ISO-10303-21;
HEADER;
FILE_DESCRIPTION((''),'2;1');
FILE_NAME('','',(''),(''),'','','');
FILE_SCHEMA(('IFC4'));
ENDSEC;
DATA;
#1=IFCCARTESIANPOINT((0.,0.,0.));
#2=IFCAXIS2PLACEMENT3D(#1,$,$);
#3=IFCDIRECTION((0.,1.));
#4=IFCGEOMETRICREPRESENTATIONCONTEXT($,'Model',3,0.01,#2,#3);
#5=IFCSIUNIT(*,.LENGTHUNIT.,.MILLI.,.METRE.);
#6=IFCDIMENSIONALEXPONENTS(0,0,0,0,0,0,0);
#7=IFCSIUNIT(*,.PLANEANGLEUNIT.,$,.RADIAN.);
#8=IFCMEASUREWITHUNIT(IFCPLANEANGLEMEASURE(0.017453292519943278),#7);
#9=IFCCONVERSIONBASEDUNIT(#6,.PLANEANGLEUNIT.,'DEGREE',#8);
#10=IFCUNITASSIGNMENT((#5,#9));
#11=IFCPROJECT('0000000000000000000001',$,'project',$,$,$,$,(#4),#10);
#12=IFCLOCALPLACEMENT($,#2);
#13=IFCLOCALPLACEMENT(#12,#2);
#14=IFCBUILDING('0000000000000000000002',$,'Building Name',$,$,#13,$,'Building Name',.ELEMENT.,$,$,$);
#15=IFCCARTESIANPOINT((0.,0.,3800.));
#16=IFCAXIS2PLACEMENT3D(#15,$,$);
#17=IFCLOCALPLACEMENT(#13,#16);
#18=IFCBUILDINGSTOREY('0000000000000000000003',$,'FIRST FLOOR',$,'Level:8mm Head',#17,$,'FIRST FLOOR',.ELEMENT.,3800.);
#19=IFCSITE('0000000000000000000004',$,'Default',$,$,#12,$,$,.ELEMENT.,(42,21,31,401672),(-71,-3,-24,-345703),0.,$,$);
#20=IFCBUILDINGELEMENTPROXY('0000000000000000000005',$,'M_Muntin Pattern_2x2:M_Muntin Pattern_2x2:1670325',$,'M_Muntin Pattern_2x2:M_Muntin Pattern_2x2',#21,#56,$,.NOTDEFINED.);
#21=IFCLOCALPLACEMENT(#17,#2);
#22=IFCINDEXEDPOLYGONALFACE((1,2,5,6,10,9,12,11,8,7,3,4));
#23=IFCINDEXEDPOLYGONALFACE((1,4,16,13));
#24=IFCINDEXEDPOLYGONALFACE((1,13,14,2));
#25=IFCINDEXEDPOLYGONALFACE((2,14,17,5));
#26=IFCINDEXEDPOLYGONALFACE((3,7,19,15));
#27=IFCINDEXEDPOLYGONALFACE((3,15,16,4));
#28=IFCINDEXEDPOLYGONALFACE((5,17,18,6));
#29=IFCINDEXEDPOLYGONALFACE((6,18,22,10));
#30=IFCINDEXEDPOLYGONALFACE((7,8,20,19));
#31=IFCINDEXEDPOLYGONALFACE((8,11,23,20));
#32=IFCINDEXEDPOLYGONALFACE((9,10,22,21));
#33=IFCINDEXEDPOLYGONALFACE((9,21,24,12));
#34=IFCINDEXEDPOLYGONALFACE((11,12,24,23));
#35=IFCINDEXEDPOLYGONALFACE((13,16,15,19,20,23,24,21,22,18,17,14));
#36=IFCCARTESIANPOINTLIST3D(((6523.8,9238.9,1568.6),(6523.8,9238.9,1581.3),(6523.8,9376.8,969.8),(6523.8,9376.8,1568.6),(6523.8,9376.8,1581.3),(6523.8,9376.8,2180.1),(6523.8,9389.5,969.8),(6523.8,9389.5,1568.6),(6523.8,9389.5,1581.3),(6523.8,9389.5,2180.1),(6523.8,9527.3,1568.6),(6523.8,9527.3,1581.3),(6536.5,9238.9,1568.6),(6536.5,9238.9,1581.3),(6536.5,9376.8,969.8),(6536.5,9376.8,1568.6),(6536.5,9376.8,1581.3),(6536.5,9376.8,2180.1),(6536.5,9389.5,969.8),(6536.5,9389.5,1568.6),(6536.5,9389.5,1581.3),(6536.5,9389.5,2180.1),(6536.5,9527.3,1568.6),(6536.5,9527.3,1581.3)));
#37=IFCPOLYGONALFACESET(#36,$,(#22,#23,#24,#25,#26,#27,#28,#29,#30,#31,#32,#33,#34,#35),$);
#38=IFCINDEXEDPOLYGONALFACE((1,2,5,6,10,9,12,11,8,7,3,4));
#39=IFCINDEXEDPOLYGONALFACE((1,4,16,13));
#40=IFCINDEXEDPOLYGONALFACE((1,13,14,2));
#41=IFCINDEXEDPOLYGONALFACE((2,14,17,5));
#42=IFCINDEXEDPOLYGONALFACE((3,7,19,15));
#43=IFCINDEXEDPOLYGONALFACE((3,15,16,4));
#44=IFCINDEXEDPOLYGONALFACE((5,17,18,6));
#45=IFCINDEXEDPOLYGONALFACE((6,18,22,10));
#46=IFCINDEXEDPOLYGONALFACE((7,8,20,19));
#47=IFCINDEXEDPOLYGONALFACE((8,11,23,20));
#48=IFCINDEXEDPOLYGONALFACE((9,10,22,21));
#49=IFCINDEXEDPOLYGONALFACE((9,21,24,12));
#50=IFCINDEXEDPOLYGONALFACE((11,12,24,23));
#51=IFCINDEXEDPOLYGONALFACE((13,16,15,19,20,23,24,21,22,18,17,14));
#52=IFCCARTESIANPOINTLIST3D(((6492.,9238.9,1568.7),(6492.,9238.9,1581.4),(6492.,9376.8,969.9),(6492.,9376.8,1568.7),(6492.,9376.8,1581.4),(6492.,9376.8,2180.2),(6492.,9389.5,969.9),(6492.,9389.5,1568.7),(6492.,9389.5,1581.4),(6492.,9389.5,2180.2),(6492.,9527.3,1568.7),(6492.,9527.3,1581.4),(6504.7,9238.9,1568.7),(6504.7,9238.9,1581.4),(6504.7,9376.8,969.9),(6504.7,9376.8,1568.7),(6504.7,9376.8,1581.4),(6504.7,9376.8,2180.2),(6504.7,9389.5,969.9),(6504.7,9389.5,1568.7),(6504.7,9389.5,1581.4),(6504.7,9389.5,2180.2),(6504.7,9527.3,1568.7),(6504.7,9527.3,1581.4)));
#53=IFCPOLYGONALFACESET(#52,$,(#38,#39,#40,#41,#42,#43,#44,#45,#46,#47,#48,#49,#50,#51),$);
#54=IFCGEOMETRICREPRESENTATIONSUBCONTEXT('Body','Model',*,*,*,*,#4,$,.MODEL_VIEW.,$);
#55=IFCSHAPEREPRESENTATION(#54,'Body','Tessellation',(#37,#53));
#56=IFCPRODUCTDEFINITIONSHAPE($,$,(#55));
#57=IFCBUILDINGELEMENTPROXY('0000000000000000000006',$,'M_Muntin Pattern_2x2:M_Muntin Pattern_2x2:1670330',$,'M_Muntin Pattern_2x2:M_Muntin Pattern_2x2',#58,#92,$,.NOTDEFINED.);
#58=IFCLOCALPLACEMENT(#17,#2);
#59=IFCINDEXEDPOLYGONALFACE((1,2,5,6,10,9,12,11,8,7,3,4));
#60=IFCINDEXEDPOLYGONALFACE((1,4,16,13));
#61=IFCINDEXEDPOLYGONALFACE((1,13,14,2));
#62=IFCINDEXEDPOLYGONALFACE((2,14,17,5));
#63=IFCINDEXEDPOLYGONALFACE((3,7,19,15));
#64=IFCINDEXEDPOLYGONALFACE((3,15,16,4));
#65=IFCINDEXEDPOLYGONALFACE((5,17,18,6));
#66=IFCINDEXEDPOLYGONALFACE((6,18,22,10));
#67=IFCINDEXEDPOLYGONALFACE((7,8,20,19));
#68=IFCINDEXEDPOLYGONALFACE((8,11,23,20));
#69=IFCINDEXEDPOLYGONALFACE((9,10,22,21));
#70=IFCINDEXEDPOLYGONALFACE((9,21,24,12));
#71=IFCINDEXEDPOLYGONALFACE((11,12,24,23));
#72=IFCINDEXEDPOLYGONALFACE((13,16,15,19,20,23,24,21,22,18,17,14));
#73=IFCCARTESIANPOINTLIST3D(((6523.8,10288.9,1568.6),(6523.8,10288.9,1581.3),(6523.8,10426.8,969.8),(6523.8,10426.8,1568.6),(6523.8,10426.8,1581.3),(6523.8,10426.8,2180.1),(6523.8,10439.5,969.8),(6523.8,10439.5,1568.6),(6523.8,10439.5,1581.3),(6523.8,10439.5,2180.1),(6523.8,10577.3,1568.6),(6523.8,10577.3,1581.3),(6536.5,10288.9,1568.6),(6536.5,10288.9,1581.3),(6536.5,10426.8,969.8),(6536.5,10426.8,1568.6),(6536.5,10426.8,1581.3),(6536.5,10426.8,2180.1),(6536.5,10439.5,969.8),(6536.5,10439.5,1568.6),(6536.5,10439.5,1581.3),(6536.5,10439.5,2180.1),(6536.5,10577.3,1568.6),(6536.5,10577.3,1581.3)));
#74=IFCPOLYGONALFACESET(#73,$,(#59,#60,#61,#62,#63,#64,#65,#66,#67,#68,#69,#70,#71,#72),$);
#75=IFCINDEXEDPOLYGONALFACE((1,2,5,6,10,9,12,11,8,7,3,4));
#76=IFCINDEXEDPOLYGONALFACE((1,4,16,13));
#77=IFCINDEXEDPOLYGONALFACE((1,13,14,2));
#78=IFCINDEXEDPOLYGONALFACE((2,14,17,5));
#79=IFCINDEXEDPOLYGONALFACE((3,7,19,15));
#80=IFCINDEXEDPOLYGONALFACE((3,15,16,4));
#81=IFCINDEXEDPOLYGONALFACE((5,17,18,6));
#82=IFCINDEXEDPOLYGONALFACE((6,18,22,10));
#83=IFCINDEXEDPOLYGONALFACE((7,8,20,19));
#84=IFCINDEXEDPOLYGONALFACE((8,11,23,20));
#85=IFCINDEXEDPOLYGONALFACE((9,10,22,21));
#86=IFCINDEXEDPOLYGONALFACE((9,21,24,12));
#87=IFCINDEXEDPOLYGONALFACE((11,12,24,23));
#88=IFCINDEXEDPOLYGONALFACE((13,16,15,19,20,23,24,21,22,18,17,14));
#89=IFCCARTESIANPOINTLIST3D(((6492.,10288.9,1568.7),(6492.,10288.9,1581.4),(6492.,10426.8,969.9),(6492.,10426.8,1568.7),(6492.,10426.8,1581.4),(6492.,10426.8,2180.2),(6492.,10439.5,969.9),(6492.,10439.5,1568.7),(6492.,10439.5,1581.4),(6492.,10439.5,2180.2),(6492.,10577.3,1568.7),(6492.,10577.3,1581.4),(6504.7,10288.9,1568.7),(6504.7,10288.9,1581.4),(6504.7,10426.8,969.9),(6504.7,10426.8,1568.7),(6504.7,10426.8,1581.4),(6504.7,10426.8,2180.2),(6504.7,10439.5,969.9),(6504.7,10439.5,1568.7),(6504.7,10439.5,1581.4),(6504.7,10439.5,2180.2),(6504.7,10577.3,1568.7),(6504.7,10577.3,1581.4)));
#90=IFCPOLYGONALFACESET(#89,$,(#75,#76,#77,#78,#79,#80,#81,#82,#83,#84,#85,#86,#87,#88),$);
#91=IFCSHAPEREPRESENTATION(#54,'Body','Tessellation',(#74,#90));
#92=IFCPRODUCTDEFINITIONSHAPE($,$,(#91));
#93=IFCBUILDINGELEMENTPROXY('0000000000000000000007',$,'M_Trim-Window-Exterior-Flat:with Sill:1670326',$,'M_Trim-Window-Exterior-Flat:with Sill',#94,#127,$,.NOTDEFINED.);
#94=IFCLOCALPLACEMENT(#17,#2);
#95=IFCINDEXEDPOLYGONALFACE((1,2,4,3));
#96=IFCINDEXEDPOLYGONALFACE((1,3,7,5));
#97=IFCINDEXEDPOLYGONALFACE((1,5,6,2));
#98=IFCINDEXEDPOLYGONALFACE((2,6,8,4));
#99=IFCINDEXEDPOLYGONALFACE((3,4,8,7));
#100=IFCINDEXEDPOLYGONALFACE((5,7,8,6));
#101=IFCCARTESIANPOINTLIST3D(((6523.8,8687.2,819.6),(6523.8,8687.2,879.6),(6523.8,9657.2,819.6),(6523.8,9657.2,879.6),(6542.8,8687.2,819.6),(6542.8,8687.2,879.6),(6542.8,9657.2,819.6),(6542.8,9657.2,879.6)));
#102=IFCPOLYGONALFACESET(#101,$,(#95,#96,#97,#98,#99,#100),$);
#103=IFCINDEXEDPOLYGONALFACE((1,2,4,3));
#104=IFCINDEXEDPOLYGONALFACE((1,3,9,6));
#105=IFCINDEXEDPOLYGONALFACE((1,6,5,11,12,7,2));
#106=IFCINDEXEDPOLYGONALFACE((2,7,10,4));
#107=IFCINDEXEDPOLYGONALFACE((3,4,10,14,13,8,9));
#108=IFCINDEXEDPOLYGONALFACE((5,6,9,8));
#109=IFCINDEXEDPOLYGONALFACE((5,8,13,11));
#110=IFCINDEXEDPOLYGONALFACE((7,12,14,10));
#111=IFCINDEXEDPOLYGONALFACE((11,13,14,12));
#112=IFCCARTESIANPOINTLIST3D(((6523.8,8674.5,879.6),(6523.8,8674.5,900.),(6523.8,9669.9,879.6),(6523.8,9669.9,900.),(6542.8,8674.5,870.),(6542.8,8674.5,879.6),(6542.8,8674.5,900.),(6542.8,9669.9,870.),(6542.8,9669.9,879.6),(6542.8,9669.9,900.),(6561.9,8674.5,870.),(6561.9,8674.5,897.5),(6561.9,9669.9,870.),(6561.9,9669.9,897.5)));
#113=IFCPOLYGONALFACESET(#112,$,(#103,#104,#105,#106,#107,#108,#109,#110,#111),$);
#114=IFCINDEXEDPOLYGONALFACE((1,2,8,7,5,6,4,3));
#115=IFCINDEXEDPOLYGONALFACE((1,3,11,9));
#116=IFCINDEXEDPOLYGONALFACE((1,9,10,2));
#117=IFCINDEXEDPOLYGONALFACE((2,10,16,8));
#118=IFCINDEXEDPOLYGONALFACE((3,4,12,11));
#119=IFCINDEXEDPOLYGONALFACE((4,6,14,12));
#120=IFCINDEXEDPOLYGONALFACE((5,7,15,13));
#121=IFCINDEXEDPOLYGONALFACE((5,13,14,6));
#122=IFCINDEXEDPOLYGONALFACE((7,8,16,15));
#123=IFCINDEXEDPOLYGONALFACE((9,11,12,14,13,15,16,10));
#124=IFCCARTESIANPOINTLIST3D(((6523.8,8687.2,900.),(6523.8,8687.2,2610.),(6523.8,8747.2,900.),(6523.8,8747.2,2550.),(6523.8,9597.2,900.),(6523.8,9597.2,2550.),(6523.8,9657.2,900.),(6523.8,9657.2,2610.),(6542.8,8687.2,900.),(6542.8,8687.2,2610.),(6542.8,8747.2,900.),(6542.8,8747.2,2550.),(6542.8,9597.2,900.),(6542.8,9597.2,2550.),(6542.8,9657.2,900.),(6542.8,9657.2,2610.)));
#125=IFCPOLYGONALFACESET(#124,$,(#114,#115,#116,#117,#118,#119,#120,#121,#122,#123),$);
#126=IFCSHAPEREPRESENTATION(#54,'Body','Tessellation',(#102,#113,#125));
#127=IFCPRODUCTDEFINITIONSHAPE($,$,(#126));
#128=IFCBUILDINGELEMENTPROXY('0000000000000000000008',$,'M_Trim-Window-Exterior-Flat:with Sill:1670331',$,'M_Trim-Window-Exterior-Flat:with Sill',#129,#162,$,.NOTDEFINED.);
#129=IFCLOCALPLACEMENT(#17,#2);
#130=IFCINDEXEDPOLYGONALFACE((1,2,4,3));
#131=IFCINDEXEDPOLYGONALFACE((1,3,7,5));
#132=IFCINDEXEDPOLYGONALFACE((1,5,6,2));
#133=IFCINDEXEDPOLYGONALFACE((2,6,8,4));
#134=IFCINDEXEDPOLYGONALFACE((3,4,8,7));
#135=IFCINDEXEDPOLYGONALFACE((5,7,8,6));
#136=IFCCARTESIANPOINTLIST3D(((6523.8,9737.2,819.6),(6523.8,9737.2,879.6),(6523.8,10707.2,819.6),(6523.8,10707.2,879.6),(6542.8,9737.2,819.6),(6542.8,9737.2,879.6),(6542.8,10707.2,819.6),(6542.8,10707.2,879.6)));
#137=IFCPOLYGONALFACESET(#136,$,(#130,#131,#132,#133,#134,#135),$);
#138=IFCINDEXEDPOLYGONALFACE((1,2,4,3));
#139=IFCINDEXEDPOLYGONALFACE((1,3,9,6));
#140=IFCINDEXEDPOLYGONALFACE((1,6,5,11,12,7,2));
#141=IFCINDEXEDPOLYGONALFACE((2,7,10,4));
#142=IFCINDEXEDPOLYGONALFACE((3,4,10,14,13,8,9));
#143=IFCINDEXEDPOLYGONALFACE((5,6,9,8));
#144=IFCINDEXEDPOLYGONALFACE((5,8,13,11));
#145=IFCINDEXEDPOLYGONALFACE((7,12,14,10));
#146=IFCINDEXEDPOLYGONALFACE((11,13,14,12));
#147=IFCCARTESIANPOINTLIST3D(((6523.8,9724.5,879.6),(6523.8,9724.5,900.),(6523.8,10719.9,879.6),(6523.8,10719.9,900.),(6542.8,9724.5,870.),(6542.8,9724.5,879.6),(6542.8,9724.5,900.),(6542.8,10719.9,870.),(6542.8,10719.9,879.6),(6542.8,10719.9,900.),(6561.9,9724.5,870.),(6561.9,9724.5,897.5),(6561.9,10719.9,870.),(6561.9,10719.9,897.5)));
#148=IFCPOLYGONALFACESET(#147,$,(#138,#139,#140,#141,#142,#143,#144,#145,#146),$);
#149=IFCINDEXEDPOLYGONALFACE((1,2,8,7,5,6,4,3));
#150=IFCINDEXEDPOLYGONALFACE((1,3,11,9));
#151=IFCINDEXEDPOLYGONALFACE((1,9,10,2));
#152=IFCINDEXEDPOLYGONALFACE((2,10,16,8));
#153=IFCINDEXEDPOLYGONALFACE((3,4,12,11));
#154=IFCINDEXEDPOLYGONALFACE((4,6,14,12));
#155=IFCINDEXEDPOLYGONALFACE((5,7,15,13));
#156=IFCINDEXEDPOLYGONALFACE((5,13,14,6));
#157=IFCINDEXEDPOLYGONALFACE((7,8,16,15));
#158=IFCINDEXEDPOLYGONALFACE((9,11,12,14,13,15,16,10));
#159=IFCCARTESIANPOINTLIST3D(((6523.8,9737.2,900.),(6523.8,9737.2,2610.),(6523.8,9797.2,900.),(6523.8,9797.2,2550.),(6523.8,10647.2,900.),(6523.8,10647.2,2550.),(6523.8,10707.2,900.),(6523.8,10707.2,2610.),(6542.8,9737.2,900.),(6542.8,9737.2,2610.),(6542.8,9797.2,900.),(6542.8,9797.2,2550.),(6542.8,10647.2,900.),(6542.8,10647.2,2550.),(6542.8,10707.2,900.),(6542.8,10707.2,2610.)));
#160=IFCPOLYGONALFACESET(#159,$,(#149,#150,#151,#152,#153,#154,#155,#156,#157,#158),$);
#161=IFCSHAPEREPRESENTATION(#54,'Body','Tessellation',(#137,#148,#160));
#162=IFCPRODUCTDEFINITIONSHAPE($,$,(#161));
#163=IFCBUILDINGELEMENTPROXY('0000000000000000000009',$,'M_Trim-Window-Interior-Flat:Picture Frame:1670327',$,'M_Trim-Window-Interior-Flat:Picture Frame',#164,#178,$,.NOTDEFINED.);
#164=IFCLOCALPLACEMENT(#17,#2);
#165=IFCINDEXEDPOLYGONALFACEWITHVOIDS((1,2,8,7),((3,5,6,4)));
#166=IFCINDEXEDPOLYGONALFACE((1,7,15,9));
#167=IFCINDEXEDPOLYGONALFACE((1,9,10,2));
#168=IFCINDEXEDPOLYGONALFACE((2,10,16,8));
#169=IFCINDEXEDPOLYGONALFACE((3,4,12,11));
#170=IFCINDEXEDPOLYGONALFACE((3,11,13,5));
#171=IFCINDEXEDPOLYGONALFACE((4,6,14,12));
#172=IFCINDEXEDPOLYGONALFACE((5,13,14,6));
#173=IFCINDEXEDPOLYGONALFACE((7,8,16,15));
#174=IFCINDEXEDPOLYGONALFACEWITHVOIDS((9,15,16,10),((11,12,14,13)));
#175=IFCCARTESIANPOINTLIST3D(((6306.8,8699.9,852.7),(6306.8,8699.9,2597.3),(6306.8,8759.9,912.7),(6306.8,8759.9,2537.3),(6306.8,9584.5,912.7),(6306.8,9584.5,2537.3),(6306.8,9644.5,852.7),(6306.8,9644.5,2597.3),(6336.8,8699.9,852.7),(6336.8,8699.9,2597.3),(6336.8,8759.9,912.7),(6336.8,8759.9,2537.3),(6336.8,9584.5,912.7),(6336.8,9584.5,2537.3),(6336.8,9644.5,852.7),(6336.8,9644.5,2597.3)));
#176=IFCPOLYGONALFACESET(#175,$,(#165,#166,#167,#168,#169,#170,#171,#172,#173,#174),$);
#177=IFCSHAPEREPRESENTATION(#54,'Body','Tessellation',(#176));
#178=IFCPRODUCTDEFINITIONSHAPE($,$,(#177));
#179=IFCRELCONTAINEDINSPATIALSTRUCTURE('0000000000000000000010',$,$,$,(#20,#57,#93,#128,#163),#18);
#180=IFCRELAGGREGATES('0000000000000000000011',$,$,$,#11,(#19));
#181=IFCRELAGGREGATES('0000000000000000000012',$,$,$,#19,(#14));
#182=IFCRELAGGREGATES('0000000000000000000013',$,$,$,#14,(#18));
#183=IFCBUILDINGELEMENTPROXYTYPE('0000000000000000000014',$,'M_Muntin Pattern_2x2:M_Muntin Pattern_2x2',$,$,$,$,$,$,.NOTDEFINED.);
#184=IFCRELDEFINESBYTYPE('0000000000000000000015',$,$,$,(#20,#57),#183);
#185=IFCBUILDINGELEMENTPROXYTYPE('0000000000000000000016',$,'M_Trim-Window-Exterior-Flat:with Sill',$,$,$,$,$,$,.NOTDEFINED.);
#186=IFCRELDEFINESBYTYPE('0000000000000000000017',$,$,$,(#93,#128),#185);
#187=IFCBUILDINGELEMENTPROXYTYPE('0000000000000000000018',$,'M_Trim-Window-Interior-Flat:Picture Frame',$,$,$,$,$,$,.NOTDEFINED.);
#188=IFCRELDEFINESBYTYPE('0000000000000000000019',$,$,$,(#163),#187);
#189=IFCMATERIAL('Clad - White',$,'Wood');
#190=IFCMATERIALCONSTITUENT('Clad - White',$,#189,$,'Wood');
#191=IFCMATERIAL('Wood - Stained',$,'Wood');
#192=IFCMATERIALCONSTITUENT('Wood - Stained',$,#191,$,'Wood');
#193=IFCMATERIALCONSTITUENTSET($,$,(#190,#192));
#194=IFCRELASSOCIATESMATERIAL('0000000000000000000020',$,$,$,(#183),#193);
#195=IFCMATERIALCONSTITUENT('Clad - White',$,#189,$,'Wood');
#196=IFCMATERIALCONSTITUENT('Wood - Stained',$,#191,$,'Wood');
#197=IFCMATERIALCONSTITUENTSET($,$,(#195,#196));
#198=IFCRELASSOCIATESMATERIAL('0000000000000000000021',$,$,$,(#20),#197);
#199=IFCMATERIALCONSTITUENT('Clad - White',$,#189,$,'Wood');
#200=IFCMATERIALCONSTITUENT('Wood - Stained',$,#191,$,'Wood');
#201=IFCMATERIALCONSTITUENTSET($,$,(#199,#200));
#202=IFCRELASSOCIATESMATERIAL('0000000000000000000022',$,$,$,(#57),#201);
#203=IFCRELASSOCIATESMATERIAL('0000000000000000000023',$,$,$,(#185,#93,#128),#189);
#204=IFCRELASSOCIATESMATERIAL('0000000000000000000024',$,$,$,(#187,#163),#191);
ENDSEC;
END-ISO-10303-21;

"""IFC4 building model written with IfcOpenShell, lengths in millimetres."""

from ifc_helpers import new_model, entity, si_unit, converted_unit, direction, frame, origin, place, context, subcontext, project, spatial, indexed_curve, outline, extrude, source, transform, mapped, material, constituent, constituent_set, type_object, type_shapes, element, save


model = new_model("IFC4")

# Units and contexts
model_context = context("Model", 3, precision=0.01, world=origin(), true_north=direction((0.0, 1.0)))
body_context = subcontext(model_context, "Body", "Model", "MODEL_VIEW")
ifc_project = project(units=[si_unit("LENGTHUNIT", "METRE", prefix="MILLI"), converted_unit("PLANEANGLEUNIT", "DEGREE", entity("IfcPlaneAngleMeasure", 0.017453292519943278), si_unit("PLANEANGLEUNIT", "RADIAN"), dimensions=[0, 0, 0, 0, 0, 0, 0])], contexts=[model_context])

# Site, building, storey
site_placement = place(None, origin())
site = spatial("IfcSite", under=ifc_project, at=site_placement, Name="Default", CompositionType="ELEMENT", RefLatitude=(42, 21, 31, 401672), RefLongitude=(-71, -3, -24, -345703), RefElevation=0.0)
building_placement = place(site_placement, origin())
building = spatial("IfcBuilding", under=site, at=building_placement, Name="Building Name", LongName="Building Name", CompositionType="ELEMENT")
storey_placement = place(building_placement, frame((0.0, 0.0, 3800.0)))
storey = spatial("IfcBuildingStorey", under=building, at=storey_placement, Name="FIRST FLOOR", ObjectType="Level:8mm Head", LongName="FIRST FLOOR", CompositionType="ELEMENT", Elevation=3800.0)

# Building element proxies
ifc_material_1 = material(Name="Clad - White", Category="Wood")
ifc_material_2 = material(Name="Wood - Stained", Category="Wood")
ifc_constituent_1 = constituent(ifc_material_1, Name="Clad - White", Category="Wood")
ifc_constituent_2 = constituent(ifc_material_2, Name="Wood - Stained", Category="Wood")
ifc_constituent_set_1 = constituent_set(constituents=[ifc_constituent_1, ifc_constituent_2])
ifc_constituent_3 = constituent(ifc_material_1, Name="Clad - White", Category="Wood")
ifc_constituent_4 = constituent(ifc_material_2, Name="Wood - Stained", Category="Wood")
ifc_constituent_set_2 = constituent_set(constituents=[ifc_constituent_3, ifc_constituent_4])
building_element_proxy_type_1 = type_object("IfcBuildingElementProxyType", Name="M_Muntin Pattern_2x2:M_Muntin Pattern_2x2", PredefinedType="NOTDEFINED", material=ifc_constituent_set_2)
shared_shape_1 = source(origin(), body_context, "Body", "SweptSolid", [
    extrude(outline(indexed_curve([(6.4, -6.4), (605.1, -6.4), (605.1, 6.3), (6.4, 6.3), (6.4, 144.2), (-6.3, 144.2), (-6.3, 6.3), (-605.2, 6.3), (-605.2, -6.4), (-6.3, -6.4), (-6.3, -144.2), (6.4, -144.2), (6.4, -6.4)], self_intersect=False)), frame((0.0, 9.5, 605.1), z_axis=(0.0, 1.0, 0.0), x_axis=(0.0, 0.0, 1.0)), (0.0, 0.0, 1.0), 12.7),
    extrude(outline(indexed_curve([(6.4, -6.4), (605.2, -6.4), (605.2, 6.3), (6.4, 6.3), (6.4, 144.2), (-6.3, 144.2), (-6.3, 6.3), (-605.2, 6.3), (-605.2, -6.4), (-6.3, -6.4), (-6.3, -144.2), (6.4, -144.2), (6.4, -6.4)], self_intersect=False)), frame((0.0, -22.2, 605.2), z_axis=(0.0, 1.0, 0.0), x_axis=(0.0, 0.0, 1.0)), (0.0, 0.0, 1.0), 12.7),
])
type_shapes(building_element_proxy_type_1, [shared_shape_1])
proxy_1_placement = place(storey_placement, frame((6514.3, 9383.1, 969.9), z_axis=(0.0, 0.0, 1.0), x_axis=(0.0, -1.0, 0.0)))
element("IfcBuildingElementProxy", 1, at=proxy_1_placement, inside=storey, type_object=building_element_proxy_type_1, material=ifc_constituent_set_1, Name="M_Muntin Pattern_2x2:M_Muntin Pattern_2x2:1670325", ObjectType="M_Muntin Pattern_2x2:M_Muntin Pattern_2x2", PredefinedType="NOTDEFINED", context=body_context, shape_type="MappedRepresentation", body=[
    mapped(shared_shape_1, transform((0.0, 0.0, 0.0), scale=1.0)),
])
ifc_constituent_5 = constituent(ifc_material_1, Name="Clad - White", Category="Wood")
ifc_constituent_6 = constituent(ifc_material_2, Name="Wood - Stained", Category="Wood")
ifc_constituent_set_3 = constituent_set(constituents=[ifc_constituent_5, ifc_constituent_6])
proxy_2_placement = place(storey_placement, frame((6514.3, 10433.1, 969.9), z_axis=(0.0, 0.0, 1.0), x_axis=(0.0, -1.0, 0.0)))
element("IfcBuildingElementProxy", 2, at=proxy_2_placement, inside=storey, type_object=building_element_proxy_type_1, material=ifc_constituent_set_3, Name="M_Muntin Pattern_2x2:M_Muntin Pattern_2x2:1670330", ObjectType="M_Muntin Pattern_2x2:M_Muntin Pattern_2x2", PredefinedType="NOTDEFINED", context=body_context, shape_type="MappedRepresentation", body=[
    mapped(shared_shape_1, transform((0.0, 0.0, 0.0), scale=1.0)),
])
building_element_proxy_type_2 = type_object("IfcBuildingElementProxyType", Name="M_Trim-Window-Exterior-Flat:with Sill", PredefinedType="NOTDEFINED", material=ifc_material_1)
shared_shape_2 = source(origin(), body_context, "Body", "SweptSolid", [
    extrude(outline(indexed_curve([(-30.0, -485.0), (30.0, -485.0), (30.0, 485.0), (-30.0, 485.0), (-30.0, -485.0)], self_intersect=False)), frame((0.0, 1700.4, 0.0), z_axis=(0.0, 0.0, 1.0), x_axis=(0.0, 1.0, 0.0)), (0.0, 0.0, 1.0), 19.0),
    extrude(outline(indexed_curve([(-15.2, -19.0), (12.3, -19.0), (14.8, 0.0), (14.8, 19.0), (-5.7, 19.0), (-5.7, 0.0), (-15.2, 0.0), (-15.2, -19.0)], self_intersect=False)), frame((-497.7, 1664.8, 19.0), z_axis=(1.0, 0.0, 0.0), x_axis=(0.0, -1.0, 0.0)), (0.0, 0.0, 1.0), 995.4),
    extrude(outline(indexed_curve([(-485.0, -870.0), (485.0, -870.0), (485.0, 840.0), (425.0, 840.0), (425.0, -810.0), (-425.0, -810.0), (-425.0, 840.0), (-485.0, 840.0), (-485.0, -870.0)], self_intersect=False)), frame((0.0, 810.0, 0.0)), (0.0, 0.0, 1.0), 19.0),
])
type_shapes(building_element_proxy_type_2, [shared_shape_2])
for number, where, z_axis, x_axis, name in (
    (3, (6523.8, 9172.2, 2550.0), (1.0, 0.0, 0.0), (0.0, -1.0, 0.0), "M_Trim-Window-Exterior-Flat:with Sill:1670326"),
    (4, (6523.8, 10222.2, 2550.0), (1.0, 0.0, 0.0), (0.0, -1.0, 0.0), "M_Trim-Window-Exterior-Flat:with Sill:1670331"),
):
    element("IfcBuildingElementProxy", number, at=place(storey_placement, frame(where, z_axis=z_axis, x_axis=x_axis)), inside=storey, type_object=building_element_proxy_type_2, material=ifc_material_1, Name=name, ObjectType="M_Trim-Window-Exterior-Flat:with Sill", PredefinedType="NOTDEFINED", context=body_context, shape_type="MappedRepresentation", body=[
        mapped(shared_shape_2, transform((0.0, 0.0, 0.0), scale=1.0)),
    ])
building_element_proxy_type_3 = type_object("IfcBuildingElementProxyType", Name="M_Trim-Window-Interior-Flat:Picture Frame", PredefinedType="NOTDEFINED", material=ifc_material_2)
shared_shape_3 = source(origin(), body_context, "Body", "SweptSolid", [
    extrude(outline(indexed_curve([(-872.3, -472.3), (872.3, -472.3), (872.3, 472.3), (-872.3, 472.3), (-872.3, -472.3)], self_intersect=False), holes=[indexed_curve([(-812.3, -412.3), (-812.3, 412.3), (812.3, 412.3), (812.3, -412.3), (-812.3, -412.3)], self_intersect=False)]), frame((0.0, 825.0, 0.0), z_axis=(0.0, 0.0, 1.0), x_axis=(0.0, 1.0, 0.0)), (0.0, 0.0, 1.0), 30.0),
])
type_shapes(building_element_proxy_type_3, [shared_shape_3])
for number, where, z_axis, x_axis, name in (
    (5, (6336.8, 9172.2, 2550.0), (-1.0, 0.0, 0.0), (0.0, 1.0, 0.0), "M_Trim-Window-Interior-Flat:Picture Frame:1670327"),
):
    element("IfcBuildingElementProxy", number, at=place(storey_placement, frame(where, z_axis=z_axis, x_axis=x_axis)), inside=storey, type_object=building_element_proxy_type_3, material=ifc_material_2, Name=name, ObjectType="M_Trim-Window-Interior-Flat:Picture Frame", PredefinedType="NOTDEFINED", context=body_context, shape_type="MappedRepresentation", body=[
        mapped(shared_shape_3, transform((0.0, 0.0, 0.0), scale=1.0)),
    ])

save(model, "model.ifc")
